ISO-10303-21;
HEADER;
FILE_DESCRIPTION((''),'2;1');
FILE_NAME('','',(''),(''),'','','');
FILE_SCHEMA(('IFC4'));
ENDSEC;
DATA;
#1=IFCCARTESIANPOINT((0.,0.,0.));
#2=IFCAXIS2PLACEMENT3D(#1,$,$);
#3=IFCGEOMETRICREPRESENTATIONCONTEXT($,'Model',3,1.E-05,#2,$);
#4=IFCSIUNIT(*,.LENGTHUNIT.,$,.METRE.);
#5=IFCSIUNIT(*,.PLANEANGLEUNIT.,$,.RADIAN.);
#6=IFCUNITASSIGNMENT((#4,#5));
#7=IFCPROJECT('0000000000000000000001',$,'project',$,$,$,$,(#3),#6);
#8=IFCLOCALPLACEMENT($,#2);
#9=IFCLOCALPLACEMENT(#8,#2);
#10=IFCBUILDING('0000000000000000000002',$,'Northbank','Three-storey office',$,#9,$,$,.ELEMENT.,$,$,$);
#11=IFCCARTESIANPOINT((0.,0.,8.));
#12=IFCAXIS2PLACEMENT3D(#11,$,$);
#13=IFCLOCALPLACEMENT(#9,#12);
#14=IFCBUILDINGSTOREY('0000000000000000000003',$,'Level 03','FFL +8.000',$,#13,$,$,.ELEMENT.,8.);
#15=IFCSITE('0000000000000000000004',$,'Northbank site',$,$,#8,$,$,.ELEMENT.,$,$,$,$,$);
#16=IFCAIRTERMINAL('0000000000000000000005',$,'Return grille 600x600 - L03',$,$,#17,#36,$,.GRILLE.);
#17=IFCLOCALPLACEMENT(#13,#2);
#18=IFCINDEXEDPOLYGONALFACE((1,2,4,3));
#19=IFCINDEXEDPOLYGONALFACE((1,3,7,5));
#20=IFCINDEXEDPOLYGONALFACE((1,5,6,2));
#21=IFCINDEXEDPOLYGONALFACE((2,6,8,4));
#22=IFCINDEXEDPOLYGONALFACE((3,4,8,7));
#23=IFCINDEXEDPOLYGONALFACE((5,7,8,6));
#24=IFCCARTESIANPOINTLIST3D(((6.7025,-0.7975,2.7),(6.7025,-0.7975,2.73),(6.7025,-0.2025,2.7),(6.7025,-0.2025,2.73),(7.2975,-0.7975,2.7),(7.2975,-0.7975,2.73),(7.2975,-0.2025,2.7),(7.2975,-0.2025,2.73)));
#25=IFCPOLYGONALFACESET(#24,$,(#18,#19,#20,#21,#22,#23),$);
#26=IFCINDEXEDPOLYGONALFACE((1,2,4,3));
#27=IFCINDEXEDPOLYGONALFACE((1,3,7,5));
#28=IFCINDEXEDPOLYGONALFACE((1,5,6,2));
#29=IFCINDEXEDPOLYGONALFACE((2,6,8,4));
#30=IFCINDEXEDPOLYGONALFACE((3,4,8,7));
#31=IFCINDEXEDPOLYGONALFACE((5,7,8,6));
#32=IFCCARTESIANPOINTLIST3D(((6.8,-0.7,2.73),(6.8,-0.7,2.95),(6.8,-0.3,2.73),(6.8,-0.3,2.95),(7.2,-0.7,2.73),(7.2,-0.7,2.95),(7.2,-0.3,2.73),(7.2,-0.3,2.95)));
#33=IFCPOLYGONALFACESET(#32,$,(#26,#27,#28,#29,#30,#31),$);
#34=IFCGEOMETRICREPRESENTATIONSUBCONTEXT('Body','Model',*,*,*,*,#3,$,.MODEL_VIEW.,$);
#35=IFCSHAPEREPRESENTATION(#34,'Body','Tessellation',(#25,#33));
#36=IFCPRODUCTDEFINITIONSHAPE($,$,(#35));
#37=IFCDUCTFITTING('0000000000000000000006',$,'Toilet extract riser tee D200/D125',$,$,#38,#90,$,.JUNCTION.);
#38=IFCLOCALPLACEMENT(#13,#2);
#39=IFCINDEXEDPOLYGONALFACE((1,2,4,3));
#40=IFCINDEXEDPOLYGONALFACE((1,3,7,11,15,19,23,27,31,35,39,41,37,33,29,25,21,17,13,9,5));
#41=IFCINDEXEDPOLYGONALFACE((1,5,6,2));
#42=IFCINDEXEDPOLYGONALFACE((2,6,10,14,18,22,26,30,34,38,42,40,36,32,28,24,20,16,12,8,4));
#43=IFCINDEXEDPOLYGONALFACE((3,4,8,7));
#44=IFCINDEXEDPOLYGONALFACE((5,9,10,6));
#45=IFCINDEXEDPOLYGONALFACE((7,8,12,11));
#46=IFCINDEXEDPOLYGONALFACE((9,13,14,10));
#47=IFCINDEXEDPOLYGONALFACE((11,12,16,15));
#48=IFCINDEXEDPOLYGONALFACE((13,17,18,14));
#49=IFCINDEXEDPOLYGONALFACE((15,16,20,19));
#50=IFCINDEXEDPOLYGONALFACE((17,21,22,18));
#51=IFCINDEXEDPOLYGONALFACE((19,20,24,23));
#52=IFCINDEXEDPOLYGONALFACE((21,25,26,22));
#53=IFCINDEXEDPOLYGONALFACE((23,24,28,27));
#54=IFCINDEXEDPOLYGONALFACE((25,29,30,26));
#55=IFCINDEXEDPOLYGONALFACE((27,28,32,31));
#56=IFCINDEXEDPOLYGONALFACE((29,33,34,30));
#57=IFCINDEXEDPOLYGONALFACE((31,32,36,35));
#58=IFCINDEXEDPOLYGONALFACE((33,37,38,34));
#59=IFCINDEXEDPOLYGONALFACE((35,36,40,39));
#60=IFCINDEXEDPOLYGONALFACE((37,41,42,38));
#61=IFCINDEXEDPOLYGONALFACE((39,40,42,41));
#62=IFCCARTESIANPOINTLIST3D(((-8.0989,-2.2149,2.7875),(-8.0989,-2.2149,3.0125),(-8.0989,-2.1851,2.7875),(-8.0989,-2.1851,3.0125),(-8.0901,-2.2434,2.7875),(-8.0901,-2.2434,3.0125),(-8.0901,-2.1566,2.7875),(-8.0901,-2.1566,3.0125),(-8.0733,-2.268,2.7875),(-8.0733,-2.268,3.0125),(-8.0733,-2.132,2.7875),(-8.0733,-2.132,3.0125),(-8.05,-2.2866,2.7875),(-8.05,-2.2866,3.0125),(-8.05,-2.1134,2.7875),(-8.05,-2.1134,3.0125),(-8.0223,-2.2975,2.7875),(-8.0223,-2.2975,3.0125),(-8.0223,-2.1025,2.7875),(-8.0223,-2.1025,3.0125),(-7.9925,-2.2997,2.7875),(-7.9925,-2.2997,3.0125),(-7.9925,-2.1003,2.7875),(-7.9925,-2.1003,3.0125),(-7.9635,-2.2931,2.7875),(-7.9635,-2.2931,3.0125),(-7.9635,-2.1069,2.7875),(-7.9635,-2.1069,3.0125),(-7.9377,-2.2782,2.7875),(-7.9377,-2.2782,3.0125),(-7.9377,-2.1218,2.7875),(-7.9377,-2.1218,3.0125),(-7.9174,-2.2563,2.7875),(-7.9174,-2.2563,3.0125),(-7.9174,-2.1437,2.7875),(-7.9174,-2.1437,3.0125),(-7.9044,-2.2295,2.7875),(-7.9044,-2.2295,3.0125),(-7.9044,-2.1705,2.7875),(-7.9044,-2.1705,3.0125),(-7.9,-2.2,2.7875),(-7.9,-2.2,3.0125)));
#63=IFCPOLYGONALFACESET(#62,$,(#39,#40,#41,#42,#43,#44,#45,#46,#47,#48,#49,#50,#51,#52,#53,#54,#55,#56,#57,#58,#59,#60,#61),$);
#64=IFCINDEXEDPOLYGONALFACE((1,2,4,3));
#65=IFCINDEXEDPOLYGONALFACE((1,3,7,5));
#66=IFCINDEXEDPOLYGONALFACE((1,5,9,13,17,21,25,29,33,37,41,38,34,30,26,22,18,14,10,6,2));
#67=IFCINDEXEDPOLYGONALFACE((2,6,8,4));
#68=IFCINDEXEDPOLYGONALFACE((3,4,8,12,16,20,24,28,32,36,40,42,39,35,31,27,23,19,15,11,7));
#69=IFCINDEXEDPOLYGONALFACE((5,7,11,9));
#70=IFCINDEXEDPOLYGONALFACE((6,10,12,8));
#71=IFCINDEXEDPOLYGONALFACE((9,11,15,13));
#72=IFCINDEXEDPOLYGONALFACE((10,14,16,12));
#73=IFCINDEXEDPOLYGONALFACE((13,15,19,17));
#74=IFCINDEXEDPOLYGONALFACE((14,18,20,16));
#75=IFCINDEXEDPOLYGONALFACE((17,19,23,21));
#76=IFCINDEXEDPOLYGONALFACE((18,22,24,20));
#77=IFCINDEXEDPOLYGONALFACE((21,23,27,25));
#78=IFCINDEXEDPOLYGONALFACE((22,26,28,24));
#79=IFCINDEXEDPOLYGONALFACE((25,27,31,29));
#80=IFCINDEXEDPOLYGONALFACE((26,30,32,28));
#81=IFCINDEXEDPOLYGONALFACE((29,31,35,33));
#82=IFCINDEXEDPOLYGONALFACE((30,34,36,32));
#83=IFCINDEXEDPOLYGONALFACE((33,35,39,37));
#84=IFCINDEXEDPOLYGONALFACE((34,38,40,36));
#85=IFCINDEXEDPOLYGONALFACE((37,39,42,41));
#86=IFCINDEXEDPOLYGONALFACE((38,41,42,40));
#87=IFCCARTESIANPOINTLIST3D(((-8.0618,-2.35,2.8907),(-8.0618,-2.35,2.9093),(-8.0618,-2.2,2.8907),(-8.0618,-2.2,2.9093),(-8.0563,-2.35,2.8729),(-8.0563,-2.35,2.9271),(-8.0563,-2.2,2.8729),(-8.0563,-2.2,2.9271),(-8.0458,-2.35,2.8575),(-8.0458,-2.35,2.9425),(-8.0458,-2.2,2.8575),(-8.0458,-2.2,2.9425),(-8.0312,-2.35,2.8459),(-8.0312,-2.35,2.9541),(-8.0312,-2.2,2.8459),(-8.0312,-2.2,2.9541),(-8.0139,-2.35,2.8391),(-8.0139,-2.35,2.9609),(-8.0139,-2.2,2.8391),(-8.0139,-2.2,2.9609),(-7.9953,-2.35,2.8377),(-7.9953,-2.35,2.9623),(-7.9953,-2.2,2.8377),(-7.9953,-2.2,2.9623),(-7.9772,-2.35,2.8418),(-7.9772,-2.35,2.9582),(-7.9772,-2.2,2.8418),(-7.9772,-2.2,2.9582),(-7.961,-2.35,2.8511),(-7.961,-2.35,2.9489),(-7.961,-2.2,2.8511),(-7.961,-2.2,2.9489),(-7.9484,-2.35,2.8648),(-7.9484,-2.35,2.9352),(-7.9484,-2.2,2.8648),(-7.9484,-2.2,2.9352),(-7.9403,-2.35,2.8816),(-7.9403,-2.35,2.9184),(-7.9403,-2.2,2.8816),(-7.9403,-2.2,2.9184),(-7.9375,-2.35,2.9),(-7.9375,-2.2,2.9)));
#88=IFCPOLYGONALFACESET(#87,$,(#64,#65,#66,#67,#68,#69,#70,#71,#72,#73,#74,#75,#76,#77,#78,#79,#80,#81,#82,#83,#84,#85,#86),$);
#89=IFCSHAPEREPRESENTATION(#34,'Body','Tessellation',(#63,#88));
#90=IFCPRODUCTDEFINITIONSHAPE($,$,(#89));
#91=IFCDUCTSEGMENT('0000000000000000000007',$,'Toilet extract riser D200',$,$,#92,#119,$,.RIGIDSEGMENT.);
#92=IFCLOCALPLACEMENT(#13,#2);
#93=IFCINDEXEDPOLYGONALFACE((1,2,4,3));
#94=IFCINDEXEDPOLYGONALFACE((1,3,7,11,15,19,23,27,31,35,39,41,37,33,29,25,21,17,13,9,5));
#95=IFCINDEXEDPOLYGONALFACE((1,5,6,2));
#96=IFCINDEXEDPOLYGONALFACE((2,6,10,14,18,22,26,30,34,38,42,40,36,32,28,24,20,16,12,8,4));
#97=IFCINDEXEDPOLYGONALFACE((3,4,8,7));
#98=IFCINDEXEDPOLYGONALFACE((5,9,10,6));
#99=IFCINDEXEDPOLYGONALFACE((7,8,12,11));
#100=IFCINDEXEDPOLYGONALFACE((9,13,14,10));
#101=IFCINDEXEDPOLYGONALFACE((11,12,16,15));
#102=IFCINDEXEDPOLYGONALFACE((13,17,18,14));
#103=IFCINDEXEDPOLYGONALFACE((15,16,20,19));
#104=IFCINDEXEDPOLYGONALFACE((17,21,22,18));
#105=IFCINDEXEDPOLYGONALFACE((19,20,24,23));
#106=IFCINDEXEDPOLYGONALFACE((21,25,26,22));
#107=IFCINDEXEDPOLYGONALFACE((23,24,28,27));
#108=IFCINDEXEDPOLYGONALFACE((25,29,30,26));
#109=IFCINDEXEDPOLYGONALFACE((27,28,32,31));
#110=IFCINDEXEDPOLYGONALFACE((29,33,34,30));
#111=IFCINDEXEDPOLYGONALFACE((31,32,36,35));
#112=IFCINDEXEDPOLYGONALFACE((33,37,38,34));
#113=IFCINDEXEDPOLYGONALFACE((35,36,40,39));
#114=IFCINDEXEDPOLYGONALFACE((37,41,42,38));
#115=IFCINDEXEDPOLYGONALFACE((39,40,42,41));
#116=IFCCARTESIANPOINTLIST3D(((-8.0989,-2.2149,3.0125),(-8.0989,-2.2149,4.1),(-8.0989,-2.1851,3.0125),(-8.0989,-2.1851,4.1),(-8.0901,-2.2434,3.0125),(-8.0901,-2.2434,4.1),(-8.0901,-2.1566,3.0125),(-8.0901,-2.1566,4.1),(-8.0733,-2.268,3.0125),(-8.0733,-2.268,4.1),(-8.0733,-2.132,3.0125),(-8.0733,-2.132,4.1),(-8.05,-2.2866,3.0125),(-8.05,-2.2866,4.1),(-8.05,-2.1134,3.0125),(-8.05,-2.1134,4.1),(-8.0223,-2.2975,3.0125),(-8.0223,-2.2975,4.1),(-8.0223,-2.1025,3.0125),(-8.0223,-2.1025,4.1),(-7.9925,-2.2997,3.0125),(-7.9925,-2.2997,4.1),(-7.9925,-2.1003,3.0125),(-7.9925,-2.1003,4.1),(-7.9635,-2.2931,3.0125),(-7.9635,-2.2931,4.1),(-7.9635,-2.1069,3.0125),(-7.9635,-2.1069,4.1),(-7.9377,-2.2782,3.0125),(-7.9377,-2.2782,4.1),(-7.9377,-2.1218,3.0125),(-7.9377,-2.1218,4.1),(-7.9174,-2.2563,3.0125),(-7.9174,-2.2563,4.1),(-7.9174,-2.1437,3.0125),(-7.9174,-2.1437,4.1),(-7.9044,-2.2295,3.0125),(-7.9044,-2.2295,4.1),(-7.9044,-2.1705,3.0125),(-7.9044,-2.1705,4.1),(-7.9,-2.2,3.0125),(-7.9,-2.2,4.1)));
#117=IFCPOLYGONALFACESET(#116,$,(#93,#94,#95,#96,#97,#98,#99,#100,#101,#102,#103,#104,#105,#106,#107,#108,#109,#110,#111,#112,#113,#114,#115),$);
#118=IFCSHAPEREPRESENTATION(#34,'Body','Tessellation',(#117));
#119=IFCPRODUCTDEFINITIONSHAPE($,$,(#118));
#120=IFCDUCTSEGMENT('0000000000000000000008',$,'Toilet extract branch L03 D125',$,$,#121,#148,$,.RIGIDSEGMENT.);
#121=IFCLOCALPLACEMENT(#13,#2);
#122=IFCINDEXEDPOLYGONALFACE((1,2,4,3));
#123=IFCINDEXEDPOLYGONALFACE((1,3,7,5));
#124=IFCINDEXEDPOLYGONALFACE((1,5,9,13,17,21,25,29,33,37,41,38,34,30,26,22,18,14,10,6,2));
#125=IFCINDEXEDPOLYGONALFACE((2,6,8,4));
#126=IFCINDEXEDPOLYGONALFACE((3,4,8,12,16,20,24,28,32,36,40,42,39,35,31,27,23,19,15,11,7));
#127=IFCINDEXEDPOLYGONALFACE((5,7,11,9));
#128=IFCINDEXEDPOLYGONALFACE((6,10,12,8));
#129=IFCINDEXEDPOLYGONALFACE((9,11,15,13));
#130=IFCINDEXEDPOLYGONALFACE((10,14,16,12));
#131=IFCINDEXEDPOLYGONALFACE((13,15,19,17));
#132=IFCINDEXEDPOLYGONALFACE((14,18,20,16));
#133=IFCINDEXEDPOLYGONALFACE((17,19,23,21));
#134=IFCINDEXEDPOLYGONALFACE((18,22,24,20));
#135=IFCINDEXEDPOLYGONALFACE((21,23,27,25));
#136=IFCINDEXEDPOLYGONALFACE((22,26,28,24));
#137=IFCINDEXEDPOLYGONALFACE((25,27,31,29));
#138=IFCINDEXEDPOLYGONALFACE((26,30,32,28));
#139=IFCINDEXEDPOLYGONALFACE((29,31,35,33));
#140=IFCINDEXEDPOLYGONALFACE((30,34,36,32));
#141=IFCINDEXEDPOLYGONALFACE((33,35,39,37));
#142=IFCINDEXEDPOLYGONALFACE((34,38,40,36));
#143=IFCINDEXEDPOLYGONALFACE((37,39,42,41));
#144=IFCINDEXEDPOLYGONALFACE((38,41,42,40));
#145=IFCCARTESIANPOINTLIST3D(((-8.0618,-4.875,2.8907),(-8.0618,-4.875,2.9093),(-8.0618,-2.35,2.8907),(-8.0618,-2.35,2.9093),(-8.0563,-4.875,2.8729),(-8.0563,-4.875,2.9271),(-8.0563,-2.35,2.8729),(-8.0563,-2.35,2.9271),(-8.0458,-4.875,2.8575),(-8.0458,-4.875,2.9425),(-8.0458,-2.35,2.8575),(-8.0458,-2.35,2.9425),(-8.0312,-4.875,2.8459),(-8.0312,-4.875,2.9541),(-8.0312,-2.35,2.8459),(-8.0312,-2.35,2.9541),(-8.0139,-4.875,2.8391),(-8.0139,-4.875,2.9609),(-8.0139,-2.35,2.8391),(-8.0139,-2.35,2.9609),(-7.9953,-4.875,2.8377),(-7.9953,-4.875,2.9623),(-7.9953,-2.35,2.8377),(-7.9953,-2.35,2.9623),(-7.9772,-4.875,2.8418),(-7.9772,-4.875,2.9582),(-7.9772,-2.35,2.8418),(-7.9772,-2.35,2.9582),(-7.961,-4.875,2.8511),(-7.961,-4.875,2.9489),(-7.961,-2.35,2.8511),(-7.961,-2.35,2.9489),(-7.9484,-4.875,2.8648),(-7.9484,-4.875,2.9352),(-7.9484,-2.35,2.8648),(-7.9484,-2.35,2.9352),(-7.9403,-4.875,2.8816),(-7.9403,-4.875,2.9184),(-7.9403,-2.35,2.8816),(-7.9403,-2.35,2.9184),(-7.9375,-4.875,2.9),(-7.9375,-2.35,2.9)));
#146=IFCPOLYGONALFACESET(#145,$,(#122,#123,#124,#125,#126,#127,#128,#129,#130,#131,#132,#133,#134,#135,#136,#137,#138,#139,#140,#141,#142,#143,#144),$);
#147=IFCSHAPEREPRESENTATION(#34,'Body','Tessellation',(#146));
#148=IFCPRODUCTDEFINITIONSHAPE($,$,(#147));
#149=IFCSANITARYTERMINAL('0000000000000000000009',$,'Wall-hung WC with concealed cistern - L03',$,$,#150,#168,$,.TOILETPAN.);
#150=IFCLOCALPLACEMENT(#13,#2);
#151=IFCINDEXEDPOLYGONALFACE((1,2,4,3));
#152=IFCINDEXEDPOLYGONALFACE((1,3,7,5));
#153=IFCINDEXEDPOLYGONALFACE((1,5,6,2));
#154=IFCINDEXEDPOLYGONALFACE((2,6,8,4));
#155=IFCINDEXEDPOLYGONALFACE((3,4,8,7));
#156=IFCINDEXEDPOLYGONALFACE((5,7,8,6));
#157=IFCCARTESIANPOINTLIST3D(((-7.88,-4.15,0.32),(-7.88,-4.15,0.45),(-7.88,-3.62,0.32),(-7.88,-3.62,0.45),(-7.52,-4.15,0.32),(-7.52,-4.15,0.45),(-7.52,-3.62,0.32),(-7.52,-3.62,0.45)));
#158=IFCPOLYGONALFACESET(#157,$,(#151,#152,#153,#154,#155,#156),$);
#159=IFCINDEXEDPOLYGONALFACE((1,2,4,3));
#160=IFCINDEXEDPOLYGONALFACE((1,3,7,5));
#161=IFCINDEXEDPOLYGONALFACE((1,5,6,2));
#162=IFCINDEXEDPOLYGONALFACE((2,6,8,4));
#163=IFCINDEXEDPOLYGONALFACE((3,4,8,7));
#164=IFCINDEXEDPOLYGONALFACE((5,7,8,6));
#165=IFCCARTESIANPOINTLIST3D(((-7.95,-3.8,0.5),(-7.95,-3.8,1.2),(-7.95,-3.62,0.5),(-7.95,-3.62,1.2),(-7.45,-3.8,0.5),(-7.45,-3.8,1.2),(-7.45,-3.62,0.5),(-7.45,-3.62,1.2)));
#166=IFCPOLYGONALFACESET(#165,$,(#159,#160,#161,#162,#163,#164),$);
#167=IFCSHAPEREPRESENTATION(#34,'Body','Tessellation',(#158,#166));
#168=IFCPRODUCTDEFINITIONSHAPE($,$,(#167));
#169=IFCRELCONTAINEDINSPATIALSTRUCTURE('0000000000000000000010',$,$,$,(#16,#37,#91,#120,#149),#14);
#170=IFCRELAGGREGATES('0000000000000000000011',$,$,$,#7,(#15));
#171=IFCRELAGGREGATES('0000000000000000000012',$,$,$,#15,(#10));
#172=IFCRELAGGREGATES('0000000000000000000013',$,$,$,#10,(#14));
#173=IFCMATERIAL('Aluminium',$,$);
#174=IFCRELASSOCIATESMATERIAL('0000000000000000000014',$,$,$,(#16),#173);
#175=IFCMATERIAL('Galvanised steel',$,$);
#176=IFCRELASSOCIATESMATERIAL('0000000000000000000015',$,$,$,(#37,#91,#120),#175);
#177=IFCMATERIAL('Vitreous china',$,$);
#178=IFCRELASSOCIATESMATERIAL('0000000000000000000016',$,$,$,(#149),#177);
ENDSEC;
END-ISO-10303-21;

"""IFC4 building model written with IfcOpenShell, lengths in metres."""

from ifc_helpers import new_model, si_unit, frame, origin, place, context, subcontext, project, spatial, rectangle, circle, extrude, material, element, save


model = new_model("IFC4")

# Units and contexts
model_context = context("Model", 3, precision=1e-05, world=origin())
body_context = subcontext(model_context, "Body", "Model", "MODEL_VIEW")
ifc_project = project(units=[si_unit("LENGTHUNIT", "METRE"), si_unit("PLANEANGLEUNIT", "RADIAN")], contexts=[model_context])

# Site, building, storey
site_placement = place(None, origin())
site = spatial("IfcSite", under=ifc_project, at=site_placement, Name="Northbank site", CompositionType="ELEMENT")
building_placement = place(site_placement, origin())
building = spatial("IfcBuilding", under=site, at=building_placement, Name="Northbank", Description="Three-storey office", CompositionType="ELEMENT")
storey_placement = place(building_placement, frame((0.0, 0.0, 8.0)))
storey = spatial("IfcBuildingStorey", under=building, at=storey_placement, Name="Level 03", Description="FFL +8.000", CompositionType="ELEMENT", Elevation=8.0)

# Shared definitions
ifc_material_1 = material(Name="Galvanised steel")

# Shared definitions
ifc_material_2 = material(Name="Aluminium")

# Air terminal
air_terminal_1_placement = place(storey_placement, frame((0.0, 0.0, -8.0)))
element("IfcAirTerminal", 1, at=air_terminal_1_placement, inside=storey, material=ifc_material_2, Name="Return grille 600x600 - L03", PredefinedType="GRILLE", context=body_context, shape_type="SweptSolid", body=[
    extrude(rectangle(XDim=0.595, YDim=0.595), frame((7.0, -0.5, 10.7)), (0.0, 0.0, 1.0), 0.03),
    extrude(rectangle(XDim=0.4, YDim=0.4), frame((7.0, -0.5, 10.73)), (0.0, 0.0, 1.0), 0.22),
])

# Duct fitting
duct_fitting_1_placement = place(storey_placement, frame((0.0, 0.0, -8.0)))
element("IfcDuctFitting", 2, at=duct_fitting_1_placement, inside=storey, material=ifc_material_1, Name="Toilet extract riser tee D200/D125", PredefinedType="JUNCTION", context=body_context, shape_type="SweptSolid", body=[
    extrude(circle(Radius=0.1), frame((-8.0, -2.2, 11.0125), z_axis=(0.0, 0.0, -1.0), x_axis=(1.0, 0.0, 0.0)), (0.0, 0.0, 1.0), 0.225),
    extrude(circle(Radius=0.0625), frame((-8.0, -2.2, 10.9), z_axis=(0.0, -1.0, 0.0), x_axis=(1.0, 0.0, 0.0)), (0.0, 0.0, 1.0), 0.15),
])

# Duct segment
duct_segment_1_placement = place(storey_placement, frame((0.0, 0.0, -8.0)))
element("IfcDuctSegment", 3, at=duct_segment_1_placement, inside=storey, material=ifc_material_1, Name="Toilet extract riser D200", PredefinedType="RIGIDSEGMENT", context=body_context, shape_type="SweptSolid", body=[
    extrude(circle(Radius=0.1), frame((-8.0, -2.2, 12.1), z_axis=(0.0, 0.0, -1.0), x_axis=(1.0, 0.0, 0.0)), (0.0, 0.0, 1.0), 1.0875),
])

# Duct segment
duct_segment_2_placement = place(storey_placement, frame((0.0, 0.0, -8.0)))
element("IfcDuctSegment", 4, at=duct_segment_2_placement, inside=storey, material=ifc_material_1, Name="Toilet extract branch L03 D125", PredefinedType="RIGIDSEGMENT", context=body_context, shape_type="SweptSolid", body=[
    extrude(circle(Radius=0.0625), frame((-8.0, -2.35, 10.9), z_axis=(0.0, -1.0, 0.0), x_axis=(1.0, 0.0, 0.0)), (0.0, 0.0, 1.0), 2.525),
])

# Sanitary terminal
ifc_material_3 = material(Name="Vitreous china")
sanitary_terminal_placement = place(storey_placement, frame((0.0, 0.0, -8.0)))
element("IfcSanitaryTerminal", 5, at=sanitary_terminal_placement, inside=storey, material=ifc_material_3, Name="Wall-hung WC with concealed cistern - L03", PredefinedType="TOILETPAN", context=body_context, shape_type="SweptSolid", body=[
    extrude(rectangle(XDim=0.36, YDim=0.53), frame((-7.7, -3.885, 8.32)), (0.0, 0.0, 1.0), 0.13),
    extrude(rectangle(XDim=0.5, YDim=0.18), frame((-7.7, -3.71, 8.5)), (0.0, 0.0, 1.0), 0.7),
])

save(model, "model.ifc")
